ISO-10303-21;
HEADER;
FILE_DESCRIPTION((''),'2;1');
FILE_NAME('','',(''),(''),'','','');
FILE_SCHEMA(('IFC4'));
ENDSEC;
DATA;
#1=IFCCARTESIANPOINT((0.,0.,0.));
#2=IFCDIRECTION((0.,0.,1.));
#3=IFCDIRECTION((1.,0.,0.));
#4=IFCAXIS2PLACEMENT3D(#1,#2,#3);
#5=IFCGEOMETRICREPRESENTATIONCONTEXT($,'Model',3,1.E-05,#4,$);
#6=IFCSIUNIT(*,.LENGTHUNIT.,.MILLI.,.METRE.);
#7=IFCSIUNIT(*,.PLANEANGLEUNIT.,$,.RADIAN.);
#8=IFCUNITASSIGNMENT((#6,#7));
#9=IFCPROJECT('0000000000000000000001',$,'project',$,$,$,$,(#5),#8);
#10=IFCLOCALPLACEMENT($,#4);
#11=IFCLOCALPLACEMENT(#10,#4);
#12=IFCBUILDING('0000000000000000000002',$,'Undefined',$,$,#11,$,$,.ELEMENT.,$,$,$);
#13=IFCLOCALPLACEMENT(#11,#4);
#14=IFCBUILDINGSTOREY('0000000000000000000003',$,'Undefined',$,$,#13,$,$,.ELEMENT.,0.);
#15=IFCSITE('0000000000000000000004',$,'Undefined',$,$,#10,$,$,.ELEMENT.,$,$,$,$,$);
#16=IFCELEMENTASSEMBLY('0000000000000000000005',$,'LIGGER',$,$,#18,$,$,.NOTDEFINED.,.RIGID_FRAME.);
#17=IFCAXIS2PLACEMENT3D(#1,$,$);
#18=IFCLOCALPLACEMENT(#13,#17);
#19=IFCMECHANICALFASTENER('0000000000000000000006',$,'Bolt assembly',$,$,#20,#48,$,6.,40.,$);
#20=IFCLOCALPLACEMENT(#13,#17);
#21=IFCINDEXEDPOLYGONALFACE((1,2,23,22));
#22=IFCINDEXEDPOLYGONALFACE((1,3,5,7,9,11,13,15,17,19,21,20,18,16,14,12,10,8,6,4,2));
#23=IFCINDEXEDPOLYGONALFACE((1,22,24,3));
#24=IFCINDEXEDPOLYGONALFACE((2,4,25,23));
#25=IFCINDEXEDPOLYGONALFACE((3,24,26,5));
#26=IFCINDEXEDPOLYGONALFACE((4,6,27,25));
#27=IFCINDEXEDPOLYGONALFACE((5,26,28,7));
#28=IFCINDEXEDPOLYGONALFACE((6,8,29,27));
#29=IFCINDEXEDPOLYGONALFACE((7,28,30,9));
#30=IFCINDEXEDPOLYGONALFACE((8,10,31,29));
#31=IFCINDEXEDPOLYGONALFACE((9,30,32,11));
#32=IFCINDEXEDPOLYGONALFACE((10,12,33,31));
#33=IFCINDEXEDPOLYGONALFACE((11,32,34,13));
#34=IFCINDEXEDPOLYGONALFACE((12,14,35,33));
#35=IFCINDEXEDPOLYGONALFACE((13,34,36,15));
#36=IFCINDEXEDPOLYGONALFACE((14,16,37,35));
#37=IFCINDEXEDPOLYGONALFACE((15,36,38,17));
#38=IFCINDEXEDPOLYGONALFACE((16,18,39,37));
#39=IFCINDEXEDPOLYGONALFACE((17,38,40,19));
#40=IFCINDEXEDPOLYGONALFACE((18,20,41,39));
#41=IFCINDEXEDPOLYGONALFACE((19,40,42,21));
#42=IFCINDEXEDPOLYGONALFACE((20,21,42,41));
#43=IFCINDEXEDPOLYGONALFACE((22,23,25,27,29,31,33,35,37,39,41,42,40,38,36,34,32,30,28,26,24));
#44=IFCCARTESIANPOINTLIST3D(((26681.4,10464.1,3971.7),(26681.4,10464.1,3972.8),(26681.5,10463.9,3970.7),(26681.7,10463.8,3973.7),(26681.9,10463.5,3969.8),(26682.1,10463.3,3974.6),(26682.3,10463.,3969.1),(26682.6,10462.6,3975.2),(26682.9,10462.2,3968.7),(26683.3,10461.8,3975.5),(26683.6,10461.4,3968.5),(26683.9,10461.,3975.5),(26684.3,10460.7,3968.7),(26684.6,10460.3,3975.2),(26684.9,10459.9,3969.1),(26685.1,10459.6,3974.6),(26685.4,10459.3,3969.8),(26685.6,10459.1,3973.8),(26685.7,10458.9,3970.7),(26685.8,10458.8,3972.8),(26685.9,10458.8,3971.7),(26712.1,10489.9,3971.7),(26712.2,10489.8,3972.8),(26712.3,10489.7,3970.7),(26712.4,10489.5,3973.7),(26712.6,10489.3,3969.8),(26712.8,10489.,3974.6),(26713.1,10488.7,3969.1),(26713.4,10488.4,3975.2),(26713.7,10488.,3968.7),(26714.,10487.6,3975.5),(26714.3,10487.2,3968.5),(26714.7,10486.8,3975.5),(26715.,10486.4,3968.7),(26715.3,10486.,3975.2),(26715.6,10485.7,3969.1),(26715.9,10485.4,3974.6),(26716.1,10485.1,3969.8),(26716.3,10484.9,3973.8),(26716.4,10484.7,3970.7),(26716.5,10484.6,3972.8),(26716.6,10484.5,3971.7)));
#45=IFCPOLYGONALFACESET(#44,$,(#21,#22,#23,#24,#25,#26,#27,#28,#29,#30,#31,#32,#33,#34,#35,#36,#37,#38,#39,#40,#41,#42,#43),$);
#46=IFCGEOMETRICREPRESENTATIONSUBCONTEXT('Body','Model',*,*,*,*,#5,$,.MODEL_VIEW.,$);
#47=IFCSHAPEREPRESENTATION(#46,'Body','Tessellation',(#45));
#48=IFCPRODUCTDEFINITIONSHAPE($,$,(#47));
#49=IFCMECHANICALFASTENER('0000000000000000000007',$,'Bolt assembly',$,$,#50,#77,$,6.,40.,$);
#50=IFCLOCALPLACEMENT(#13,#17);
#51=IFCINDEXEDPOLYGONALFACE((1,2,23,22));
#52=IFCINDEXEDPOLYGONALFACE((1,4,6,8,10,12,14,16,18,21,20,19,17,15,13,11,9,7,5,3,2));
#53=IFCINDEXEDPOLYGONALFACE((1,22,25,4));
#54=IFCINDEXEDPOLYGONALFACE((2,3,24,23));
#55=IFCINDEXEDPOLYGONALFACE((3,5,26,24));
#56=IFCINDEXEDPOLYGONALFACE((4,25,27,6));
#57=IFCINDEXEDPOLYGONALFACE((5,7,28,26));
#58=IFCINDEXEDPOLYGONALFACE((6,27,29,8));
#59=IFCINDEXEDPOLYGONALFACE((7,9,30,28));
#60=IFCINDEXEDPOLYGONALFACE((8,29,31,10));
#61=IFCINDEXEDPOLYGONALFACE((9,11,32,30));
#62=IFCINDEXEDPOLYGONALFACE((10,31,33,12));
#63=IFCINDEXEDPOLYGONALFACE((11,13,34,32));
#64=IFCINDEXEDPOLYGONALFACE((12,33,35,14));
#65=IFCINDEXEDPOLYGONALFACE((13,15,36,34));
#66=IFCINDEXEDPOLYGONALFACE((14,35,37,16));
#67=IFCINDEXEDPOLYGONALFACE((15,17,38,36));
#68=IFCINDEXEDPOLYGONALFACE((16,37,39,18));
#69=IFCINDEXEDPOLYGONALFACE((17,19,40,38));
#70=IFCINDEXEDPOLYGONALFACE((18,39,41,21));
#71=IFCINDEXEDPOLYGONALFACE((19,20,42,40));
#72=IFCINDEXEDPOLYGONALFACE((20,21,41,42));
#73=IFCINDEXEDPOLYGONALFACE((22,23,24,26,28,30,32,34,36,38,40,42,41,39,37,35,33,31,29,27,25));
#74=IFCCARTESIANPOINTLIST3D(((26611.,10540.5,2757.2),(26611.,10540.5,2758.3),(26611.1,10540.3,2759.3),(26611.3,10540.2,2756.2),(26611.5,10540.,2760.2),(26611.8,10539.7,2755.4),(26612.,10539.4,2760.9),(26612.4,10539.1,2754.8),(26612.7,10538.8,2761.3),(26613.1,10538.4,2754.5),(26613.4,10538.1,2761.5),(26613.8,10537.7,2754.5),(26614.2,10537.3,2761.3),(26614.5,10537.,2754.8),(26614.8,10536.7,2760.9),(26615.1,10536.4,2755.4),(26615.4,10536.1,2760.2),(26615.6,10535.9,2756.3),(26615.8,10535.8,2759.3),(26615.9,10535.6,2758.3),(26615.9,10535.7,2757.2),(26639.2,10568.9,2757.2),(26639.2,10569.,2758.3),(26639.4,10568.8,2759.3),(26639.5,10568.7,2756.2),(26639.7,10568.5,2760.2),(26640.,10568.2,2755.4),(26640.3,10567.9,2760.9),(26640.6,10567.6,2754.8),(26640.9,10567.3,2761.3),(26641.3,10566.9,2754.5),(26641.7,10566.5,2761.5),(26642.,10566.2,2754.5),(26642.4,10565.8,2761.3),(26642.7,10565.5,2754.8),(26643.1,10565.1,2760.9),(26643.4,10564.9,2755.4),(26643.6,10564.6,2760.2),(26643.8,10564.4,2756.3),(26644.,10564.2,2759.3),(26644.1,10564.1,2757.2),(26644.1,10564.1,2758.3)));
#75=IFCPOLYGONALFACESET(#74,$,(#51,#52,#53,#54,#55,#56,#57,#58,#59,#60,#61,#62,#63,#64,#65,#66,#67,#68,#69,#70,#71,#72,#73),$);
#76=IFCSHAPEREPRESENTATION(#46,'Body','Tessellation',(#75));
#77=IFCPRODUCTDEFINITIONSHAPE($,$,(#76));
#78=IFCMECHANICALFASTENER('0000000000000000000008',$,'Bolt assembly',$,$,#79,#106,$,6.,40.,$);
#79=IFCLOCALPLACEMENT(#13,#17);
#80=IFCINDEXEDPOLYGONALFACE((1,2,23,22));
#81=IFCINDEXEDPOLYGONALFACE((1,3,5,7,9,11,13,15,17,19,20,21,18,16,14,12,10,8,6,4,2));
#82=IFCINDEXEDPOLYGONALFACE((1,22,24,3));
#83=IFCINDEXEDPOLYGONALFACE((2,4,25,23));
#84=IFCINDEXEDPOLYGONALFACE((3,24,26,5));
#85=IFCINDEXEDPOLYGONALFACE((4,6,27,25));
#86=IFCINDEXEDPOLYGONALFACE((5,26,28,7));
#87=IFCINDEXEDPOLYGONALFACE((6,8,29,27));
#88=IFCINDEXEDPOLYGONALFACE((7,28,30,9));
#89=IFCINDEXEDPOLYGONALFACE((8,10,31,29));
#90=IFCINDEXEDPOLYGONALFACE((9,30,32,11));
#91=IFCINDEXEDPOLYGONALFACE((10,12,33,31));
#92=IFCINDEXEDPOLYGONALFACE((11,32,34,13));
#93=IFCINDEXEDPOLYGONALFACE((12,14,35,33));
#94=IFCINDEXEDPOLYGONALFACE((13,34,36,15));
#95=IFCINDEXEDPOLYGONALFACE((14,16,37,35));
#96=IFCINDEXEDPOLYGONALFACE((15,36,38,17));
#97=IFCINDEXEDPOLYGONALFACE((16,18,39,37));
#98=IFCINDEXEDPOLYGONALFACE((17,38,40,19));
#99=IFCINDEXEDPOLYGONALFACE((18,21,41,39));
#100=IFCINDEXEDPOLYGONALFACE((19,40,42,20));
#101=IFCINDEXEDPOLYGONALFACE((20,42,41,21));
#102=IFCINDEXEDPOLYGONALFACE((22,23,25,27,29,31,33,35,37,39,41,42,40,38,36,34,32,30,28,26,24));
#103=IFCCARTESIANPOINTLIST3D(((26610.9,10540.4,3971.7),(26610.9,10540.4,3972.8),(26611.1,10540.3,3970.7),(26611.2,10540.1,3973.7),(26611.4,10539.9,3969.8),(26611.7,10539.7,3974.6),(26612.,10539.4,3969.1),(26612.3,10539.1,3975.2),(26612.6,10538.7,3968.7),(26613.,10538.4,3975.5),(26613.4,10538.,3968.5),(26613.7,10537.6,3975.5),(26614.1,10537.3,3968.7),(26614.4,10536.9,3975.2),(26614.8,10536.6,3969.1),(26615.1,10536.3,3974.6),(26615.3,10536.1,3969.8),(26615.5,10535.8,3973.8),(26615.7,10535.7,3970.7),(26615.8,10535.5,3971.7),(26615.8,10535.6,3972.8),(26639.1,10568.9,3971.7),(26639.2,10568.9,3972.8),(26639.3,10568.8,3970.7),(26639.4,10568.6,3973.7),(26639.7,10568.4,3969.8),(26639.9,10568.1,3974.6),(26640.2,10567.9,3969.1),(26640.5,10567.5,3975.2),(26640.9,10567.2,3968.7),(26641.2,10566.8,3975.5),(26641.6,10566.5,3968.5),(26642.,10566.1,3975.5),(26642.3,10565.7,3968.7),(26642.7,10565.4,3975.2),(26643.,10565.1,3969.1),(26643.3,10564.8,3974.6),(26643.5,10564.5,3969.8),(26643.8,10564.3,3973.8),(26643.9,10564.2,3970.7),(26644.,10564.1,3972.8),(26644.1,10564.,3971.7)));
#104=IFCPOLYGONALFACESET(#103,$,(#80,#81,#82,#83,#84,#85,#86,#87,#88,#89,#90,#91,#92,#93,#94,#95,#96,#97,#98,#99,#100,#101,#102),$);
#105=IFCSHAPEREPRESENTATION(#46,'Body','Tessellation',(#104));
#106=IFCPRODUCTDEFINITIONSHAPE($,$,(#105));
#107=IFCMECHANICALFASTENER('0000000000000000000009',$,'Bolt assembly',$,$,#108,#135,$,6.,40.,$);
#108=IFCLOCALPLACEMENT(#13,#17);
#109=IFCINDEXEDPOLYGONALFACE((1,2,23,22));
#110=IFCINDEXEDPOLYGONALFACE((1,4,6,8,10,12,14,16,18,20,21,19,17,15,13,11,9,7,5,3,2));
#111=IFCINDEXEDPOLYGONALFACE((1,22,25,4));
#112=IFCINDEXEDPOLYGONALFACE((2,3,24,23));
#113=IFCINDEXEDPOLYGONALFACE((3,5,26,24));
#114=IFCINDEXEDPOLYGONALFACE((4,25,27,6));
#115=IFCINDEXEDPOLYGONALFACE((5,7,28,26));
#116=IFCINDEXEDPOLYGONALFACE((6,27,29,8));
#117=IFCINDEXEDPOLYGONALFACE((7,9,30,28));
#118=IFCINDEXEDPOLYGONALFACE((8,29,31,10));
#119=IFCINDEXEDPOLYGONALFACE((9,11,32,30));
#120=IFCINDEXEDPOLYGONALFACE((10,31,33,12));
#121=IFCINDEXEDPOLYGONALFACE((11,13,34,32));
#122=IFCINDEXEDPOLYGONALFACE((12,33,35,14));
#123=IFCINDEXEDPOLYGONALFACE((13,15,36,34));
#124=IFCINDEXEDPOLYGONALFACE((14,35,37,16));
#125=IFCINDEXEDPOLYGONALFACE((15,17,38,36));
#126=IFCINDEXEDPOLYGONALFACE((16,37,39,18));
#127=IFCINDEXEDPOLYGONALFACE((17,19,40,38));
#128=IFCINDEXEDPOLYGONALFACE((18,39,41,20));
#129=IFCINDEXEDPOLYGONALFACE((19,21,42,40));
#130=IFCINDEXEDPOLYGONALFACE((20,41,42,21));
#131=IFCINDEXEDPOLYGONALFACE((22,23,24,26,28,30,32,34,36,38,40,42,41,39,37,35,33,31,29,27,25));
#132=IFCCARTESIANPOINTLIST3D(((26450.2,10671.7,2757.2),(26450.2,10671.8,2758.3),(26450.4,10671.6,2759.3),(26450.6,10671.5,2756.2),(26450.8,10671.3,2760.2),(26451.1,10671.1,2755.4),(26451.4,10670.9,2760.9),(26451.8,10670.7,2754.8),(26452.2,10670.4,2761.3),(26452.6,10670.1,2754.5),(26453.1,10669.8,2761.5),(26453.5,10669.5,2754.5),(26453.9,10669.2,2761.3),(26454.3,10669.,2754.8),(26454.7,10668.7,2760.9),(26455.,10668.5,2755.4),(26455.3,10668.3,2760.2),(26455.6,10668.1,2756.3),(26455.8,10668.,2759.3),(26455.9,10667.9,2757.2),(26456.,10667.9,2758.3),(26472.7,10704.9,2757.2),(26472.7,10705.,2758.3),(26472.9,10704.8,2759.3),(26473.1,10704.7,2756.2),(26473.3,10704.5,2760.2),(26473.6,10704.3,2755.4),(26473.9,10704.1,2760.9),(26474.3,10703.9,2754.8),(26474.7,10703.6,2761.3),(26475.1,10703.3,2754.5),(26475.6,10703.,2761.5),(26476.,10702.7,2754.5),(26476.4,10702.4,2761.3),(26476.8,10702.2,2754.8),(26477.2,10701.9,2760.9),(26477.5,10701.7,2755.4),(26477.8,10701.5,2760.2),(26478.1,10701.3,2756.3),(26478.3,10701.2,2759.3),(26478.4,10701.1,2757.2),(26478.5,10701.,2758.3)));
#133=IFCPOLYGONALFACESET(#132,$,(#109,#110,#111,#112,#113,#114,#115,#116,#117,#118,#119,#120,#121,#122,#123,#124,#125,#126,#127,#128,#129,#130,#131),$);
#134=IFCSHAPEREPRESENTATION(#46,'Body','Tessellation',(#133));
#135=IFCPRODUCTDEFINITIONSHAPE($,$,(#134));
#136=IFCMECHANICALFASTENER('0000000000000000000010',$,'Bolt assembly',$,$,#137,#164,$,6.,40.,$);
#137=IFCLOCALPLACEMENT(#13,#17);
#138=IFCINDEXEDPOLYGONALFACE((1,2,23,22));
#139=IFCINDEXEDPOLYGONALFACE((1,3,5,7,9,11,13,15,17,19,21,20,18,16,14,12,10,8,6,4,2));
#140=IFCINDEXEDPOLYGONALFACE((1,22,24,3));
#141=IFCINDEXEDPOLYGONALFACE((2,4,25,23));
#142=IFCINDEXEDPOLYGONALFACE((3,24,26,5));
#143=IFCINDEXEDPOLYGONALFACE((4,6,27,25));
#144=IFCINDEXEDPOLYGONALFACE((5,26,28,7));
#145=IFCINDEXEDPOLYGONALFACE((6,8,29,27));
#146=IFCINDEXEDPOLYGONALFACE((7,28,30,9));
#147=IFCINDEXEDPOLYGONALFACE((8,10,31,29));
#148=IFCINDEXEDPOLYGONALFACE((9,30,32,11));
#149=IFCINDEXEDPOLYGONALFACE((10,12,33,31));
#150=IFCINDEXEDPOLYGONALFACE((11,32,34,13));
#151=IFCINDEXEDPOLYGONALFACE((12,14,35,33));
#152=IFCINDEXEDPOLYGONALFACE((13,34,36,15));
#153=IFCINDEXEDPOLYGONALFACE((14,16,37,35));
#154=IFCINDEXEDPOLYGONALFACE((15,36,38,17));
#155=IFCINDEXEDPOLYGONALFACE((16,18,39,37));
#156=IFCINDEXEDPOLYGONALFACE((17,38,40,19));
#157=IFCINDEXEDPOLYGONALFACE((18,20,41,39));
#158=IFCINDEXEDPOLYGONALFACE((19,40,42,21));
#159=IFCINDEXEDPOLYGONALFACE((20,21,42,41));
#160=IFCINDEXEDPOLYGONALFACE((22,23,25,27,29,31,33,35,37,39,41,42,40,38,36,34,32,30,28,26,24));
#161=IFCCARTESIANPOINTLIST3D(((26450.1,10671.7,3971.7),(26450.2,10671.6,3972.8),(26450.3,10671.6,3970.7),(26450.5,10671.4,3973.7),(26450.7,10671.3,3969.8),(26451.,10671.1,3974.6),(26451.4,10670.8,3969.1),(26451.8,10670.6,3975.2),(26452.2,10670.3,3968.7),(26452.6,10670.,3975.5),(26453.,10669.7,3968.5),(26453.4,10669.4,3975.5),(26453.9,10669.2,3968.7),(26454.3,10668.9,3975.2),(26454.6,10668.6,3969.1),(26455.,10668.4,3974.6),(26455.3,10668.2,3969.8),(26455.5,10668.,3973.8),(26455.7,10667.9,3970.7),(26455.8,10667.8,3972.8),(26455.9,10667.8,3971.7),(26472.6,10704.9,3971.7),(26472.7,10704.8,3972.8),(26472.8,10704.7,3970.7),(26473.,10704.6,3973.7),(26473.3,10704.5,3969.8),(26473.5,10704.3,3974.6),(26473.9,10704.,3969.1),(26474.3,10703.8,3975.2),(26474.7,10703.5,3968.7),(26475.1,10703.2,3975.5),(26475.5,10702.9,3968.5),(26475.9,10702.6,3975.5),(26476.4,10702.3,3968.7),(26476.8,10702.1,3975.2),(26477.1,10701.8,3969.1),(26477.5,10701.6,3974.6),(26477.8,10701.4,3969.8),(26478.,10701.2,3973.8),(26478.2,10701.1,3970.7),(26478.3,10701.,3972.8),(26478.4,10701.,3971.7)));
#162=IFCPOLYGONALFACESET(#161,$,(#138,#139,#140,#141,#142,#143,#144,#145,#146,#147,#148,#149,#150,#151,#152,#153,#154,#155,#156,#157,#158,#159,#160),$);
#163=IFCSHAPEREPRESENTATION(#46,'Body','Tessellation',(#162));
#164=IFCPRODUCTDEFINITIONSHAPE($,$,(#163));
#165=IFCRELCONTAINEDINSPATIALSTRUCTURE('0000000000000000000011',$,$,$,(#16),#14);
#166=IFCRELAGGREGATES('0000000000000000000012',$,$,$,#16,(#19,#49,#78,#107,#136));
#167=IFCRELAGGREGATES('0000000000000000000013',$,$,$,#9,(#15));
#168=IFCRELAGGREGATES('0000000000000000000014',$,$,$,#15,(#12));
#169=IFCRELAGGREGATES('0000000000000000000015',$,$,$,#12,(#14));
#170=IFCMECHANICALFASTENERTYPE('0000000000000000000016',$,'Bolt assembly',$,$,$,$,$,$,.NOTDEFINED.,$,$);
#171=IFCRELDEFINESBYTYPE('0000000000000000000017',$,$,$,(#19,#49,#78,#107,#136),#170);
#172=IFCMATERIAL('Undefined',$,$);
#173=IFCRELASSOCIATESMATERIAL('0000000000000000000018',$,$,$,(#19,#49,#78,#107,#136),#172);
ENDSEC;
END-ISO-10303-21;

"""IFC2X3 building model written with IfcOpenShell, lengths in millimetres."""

from ifc_helpers import new_model, si_unit, frame, origin_with_axes, origin_2d_with_axis, place, context, subcontext, project, spatial, circle, extrude, source, transform, mapped, material, type_object, element, aggregate, save


model = new_model("IFC2X3")

# Units and contexts
model_context = context("Model", 3, precision=1e-05, world=origin_with_axes())
body_context = subcontext(model_context, "Body", "Model", "MODEL_VIEW")
ifc_project = project(units=[si_unit("LENGTHUNIT", "METRE", prefix="MILLI"), si_unit("PLANEANGLEUNIT", "RADIAN")], contexts=[model_context])

# Site, building, storey
site_placement = place(None, origin_with_axes())
site = spatial("IfcSite", under=ifc_project, at=site_placement, Name="Undefined", CompositionType="ELEMENT")
building_placement = place(site_placement, origin_with_axes())
building = spatial("IfcBuilding", under=site, at=building_placement, Name="Undefined", CompositionType="ELEMENT")
storey_placement = place(building_placement, origin_with_axes())
storey = spatial("IfcBuildingStorey", under=building, at=storey_placement, Name="Undefined", CompositionType="ELEMENT", Elevation=0.0)

# Element assembly
assembly_1_placement = place(storey_placement, origin_with_axes())
assembly_1 = element("IfcElementAssembly", 1, at=assembly_1_placement, inside=storey, Name="LIGGER", AssemblyPlace="NOTDEFINED", PredefinedType="RIGID_FRAME")

# Mechanical fasteners
ifc_material_1 = material(Name="Undefined")
mechanical_fastener_type = type_object("IfcMechanicalFastenerType", Name="Bolt assembly")
shared_shape_1 = source(origin_with_axes(), body_context, "Body", "SweptSolid", [
    extrude(circle(Radius=3.5, at=origin_2d_with_axis()), frame((0.0, -22.3, 0.0), z_axis=(0.0, 1.0, 0.0), x_axis=(1.0, 0.0, 0.0)), (0.0, 0.0, 1.0), 40.1),
])
mechanical_fastener_1_placement = place(assembly_1_placement, frame((26697.2, 10472.9, 3972.0), z_axis=(-0.642235, 0.766508, 0.0), x_axis=(0.0, 0.0, -1.0)))
mechanical_fastener_1 = element("IfcMechanicalFastener", 2, at=mechanical_fastener_1_placement, type_object=mechanical_fastener_type, material=ifc_material_1, Name="Bolt assembly", NominalDiameter=6.0, NominalLength=40.0, context=body_context, shape_type="MappedRepresentation", body=[
    mapped(shared_shape_1, transform((0.0, 0.0, 0.0))),
])
shared_shape_2 = source(origin_with_axes(), body_context, "Body", "SweptSolid", [
    extrude(circle(Radius=3.5, at=origin_2d_with_axis()), frame((0.0, -17.8, 0.0), z_axis=(0.0, 1.0, 0.0), x_axis=(1.0, 0.0, 0.0)), (0.0, 0.0, 1.0), 40.1),
])
mechanical_fastener_2_placement = place(assembly_1_placement, frame((26625.9, 10550.7, 2758.0), z_axis=(-0.710229, 0.703971, 0.0), x_axis=(0.0, 0.0, 1.0)))
mechanical_fastener_2 = element("IfcMechanicalFastener", 3, at=mechanical_fastener_2_placement, type_object=mechanical_fastener_type, material=ifc_material_1, Name="Bolt assembly", NominalDiameter=6.0, NominalLength=40.0, context=body_context, shape_type="MappedRepresentation", body=[
    mapped(shared_shape_2, transform((0.0, 0.0, 0.0))),
])
shared_shape_3 = source(origin_with_axes(), body_context, "Body", "SweptSolid", [
    extrude(circle(Radius=3.5, at=origin_2d_with_axis()), frame((0.0, -22.2, 0.0), z_axis=(0.0, 1.0, 0.0), x_axis=(1.0, 0.0, 0.0)), (0.0, 0.0, 1.0), 40.1),
])
mechanical_fastener_3_placement = place(assembly_1_placement, frame((26625.9, 10550.7, 3972.0), z_axis=(-0.710229, 0.703971, 0.0), x_axis=(0.0, 0.0, -1.0)))
mechanical_fastener_3 = element("IfcMechanicalFastener", 4, at=mechanical_fastener_3_placement, type_object=mechanical_fastener_type, material=ifc_material_1, Name="Bolt assembly", NominalDiameter=6.0, NominalLength=40.0, context=body_context, shape_type="MappedRepresentation", body=[
    mapped(shared_shape_3, transform((0.0, 0.0, 0.0))),
])
shared_shape_4 = source(origin_with_axes(), body_context, "Body", "SweptSolid", [
    extrude(circle(Radius=3.5, at=origin_2d_with_axis()), frame((0.0, -18.0, 0.0), z_axis=(0.0, 1.0, 0.0), x_axis=(1.0, 0.0, 0.0)), (0.0, 0.0, 1.0), 40.1),
])
mechanical_fastener_4_placement = place(assembly_1_placement, frame((26463.2, 10684.7, 2758.0), z_axis=(-0.827673, 0.561211, 0.0), x_axis=(0.0, 0.0, 1.0)))
mechanical_fastener_4 = element("IfcMechanicalFastener", 5, at=mechanical_fastener_4_placement, type_object=mechanical_fastener_type, material=ifc_material_1, Name="Bolt assembly", NominalDiameter=6.0, NominalLength=40.0, context=body_context, shape_type="MappedRepresentation", body=[
    mapped(shared_shape_4, transform((0.0, 0.0, 0.0))),
])
shared_shape_5 = source(origin_with_axes(), body_context, "Body", "SweptSolid", [
    extrude(circle(Radius=3.5, at=origin_2d_with_axis()), frame((0.0, -22.0, 0.0), z_axis=(0.0, 1.0, 0.0), x_axis=(1.0, 0.0, 0.0)), (0.0, 0.0, 1.0), 40.1),
])
mechanical_fastener_5_placement = place(assembly_1_placement, frame((26463.2, 10684.7, 3972.0), z_axis=(-0.827673, 0.561211, 0.0), x_axis=(0.0, 0.0, -1.0)))
mechanical_fastener_5 = element("IfcMechanicalFastener", 6, at=mechanical_fastener_5_placement, type_object=mechanical_fastener_type, material=ifc_material_1, Name="Bolt assembly", NominalDiameter=6.0, NominalLength=40.0, context=body_context, shape_type="MappedRepresentation", body=[
    mapped(shared_shape_5, transform((0.0, 0.0, 0.0))),
])
aggregate(assembly_1, [mechanical_fastener_1, mechanical_fastener_2, mechanical_fastener_3, mechanical_fastener_4, mechanical_fastener_5])

save(model, "model.ifc")
